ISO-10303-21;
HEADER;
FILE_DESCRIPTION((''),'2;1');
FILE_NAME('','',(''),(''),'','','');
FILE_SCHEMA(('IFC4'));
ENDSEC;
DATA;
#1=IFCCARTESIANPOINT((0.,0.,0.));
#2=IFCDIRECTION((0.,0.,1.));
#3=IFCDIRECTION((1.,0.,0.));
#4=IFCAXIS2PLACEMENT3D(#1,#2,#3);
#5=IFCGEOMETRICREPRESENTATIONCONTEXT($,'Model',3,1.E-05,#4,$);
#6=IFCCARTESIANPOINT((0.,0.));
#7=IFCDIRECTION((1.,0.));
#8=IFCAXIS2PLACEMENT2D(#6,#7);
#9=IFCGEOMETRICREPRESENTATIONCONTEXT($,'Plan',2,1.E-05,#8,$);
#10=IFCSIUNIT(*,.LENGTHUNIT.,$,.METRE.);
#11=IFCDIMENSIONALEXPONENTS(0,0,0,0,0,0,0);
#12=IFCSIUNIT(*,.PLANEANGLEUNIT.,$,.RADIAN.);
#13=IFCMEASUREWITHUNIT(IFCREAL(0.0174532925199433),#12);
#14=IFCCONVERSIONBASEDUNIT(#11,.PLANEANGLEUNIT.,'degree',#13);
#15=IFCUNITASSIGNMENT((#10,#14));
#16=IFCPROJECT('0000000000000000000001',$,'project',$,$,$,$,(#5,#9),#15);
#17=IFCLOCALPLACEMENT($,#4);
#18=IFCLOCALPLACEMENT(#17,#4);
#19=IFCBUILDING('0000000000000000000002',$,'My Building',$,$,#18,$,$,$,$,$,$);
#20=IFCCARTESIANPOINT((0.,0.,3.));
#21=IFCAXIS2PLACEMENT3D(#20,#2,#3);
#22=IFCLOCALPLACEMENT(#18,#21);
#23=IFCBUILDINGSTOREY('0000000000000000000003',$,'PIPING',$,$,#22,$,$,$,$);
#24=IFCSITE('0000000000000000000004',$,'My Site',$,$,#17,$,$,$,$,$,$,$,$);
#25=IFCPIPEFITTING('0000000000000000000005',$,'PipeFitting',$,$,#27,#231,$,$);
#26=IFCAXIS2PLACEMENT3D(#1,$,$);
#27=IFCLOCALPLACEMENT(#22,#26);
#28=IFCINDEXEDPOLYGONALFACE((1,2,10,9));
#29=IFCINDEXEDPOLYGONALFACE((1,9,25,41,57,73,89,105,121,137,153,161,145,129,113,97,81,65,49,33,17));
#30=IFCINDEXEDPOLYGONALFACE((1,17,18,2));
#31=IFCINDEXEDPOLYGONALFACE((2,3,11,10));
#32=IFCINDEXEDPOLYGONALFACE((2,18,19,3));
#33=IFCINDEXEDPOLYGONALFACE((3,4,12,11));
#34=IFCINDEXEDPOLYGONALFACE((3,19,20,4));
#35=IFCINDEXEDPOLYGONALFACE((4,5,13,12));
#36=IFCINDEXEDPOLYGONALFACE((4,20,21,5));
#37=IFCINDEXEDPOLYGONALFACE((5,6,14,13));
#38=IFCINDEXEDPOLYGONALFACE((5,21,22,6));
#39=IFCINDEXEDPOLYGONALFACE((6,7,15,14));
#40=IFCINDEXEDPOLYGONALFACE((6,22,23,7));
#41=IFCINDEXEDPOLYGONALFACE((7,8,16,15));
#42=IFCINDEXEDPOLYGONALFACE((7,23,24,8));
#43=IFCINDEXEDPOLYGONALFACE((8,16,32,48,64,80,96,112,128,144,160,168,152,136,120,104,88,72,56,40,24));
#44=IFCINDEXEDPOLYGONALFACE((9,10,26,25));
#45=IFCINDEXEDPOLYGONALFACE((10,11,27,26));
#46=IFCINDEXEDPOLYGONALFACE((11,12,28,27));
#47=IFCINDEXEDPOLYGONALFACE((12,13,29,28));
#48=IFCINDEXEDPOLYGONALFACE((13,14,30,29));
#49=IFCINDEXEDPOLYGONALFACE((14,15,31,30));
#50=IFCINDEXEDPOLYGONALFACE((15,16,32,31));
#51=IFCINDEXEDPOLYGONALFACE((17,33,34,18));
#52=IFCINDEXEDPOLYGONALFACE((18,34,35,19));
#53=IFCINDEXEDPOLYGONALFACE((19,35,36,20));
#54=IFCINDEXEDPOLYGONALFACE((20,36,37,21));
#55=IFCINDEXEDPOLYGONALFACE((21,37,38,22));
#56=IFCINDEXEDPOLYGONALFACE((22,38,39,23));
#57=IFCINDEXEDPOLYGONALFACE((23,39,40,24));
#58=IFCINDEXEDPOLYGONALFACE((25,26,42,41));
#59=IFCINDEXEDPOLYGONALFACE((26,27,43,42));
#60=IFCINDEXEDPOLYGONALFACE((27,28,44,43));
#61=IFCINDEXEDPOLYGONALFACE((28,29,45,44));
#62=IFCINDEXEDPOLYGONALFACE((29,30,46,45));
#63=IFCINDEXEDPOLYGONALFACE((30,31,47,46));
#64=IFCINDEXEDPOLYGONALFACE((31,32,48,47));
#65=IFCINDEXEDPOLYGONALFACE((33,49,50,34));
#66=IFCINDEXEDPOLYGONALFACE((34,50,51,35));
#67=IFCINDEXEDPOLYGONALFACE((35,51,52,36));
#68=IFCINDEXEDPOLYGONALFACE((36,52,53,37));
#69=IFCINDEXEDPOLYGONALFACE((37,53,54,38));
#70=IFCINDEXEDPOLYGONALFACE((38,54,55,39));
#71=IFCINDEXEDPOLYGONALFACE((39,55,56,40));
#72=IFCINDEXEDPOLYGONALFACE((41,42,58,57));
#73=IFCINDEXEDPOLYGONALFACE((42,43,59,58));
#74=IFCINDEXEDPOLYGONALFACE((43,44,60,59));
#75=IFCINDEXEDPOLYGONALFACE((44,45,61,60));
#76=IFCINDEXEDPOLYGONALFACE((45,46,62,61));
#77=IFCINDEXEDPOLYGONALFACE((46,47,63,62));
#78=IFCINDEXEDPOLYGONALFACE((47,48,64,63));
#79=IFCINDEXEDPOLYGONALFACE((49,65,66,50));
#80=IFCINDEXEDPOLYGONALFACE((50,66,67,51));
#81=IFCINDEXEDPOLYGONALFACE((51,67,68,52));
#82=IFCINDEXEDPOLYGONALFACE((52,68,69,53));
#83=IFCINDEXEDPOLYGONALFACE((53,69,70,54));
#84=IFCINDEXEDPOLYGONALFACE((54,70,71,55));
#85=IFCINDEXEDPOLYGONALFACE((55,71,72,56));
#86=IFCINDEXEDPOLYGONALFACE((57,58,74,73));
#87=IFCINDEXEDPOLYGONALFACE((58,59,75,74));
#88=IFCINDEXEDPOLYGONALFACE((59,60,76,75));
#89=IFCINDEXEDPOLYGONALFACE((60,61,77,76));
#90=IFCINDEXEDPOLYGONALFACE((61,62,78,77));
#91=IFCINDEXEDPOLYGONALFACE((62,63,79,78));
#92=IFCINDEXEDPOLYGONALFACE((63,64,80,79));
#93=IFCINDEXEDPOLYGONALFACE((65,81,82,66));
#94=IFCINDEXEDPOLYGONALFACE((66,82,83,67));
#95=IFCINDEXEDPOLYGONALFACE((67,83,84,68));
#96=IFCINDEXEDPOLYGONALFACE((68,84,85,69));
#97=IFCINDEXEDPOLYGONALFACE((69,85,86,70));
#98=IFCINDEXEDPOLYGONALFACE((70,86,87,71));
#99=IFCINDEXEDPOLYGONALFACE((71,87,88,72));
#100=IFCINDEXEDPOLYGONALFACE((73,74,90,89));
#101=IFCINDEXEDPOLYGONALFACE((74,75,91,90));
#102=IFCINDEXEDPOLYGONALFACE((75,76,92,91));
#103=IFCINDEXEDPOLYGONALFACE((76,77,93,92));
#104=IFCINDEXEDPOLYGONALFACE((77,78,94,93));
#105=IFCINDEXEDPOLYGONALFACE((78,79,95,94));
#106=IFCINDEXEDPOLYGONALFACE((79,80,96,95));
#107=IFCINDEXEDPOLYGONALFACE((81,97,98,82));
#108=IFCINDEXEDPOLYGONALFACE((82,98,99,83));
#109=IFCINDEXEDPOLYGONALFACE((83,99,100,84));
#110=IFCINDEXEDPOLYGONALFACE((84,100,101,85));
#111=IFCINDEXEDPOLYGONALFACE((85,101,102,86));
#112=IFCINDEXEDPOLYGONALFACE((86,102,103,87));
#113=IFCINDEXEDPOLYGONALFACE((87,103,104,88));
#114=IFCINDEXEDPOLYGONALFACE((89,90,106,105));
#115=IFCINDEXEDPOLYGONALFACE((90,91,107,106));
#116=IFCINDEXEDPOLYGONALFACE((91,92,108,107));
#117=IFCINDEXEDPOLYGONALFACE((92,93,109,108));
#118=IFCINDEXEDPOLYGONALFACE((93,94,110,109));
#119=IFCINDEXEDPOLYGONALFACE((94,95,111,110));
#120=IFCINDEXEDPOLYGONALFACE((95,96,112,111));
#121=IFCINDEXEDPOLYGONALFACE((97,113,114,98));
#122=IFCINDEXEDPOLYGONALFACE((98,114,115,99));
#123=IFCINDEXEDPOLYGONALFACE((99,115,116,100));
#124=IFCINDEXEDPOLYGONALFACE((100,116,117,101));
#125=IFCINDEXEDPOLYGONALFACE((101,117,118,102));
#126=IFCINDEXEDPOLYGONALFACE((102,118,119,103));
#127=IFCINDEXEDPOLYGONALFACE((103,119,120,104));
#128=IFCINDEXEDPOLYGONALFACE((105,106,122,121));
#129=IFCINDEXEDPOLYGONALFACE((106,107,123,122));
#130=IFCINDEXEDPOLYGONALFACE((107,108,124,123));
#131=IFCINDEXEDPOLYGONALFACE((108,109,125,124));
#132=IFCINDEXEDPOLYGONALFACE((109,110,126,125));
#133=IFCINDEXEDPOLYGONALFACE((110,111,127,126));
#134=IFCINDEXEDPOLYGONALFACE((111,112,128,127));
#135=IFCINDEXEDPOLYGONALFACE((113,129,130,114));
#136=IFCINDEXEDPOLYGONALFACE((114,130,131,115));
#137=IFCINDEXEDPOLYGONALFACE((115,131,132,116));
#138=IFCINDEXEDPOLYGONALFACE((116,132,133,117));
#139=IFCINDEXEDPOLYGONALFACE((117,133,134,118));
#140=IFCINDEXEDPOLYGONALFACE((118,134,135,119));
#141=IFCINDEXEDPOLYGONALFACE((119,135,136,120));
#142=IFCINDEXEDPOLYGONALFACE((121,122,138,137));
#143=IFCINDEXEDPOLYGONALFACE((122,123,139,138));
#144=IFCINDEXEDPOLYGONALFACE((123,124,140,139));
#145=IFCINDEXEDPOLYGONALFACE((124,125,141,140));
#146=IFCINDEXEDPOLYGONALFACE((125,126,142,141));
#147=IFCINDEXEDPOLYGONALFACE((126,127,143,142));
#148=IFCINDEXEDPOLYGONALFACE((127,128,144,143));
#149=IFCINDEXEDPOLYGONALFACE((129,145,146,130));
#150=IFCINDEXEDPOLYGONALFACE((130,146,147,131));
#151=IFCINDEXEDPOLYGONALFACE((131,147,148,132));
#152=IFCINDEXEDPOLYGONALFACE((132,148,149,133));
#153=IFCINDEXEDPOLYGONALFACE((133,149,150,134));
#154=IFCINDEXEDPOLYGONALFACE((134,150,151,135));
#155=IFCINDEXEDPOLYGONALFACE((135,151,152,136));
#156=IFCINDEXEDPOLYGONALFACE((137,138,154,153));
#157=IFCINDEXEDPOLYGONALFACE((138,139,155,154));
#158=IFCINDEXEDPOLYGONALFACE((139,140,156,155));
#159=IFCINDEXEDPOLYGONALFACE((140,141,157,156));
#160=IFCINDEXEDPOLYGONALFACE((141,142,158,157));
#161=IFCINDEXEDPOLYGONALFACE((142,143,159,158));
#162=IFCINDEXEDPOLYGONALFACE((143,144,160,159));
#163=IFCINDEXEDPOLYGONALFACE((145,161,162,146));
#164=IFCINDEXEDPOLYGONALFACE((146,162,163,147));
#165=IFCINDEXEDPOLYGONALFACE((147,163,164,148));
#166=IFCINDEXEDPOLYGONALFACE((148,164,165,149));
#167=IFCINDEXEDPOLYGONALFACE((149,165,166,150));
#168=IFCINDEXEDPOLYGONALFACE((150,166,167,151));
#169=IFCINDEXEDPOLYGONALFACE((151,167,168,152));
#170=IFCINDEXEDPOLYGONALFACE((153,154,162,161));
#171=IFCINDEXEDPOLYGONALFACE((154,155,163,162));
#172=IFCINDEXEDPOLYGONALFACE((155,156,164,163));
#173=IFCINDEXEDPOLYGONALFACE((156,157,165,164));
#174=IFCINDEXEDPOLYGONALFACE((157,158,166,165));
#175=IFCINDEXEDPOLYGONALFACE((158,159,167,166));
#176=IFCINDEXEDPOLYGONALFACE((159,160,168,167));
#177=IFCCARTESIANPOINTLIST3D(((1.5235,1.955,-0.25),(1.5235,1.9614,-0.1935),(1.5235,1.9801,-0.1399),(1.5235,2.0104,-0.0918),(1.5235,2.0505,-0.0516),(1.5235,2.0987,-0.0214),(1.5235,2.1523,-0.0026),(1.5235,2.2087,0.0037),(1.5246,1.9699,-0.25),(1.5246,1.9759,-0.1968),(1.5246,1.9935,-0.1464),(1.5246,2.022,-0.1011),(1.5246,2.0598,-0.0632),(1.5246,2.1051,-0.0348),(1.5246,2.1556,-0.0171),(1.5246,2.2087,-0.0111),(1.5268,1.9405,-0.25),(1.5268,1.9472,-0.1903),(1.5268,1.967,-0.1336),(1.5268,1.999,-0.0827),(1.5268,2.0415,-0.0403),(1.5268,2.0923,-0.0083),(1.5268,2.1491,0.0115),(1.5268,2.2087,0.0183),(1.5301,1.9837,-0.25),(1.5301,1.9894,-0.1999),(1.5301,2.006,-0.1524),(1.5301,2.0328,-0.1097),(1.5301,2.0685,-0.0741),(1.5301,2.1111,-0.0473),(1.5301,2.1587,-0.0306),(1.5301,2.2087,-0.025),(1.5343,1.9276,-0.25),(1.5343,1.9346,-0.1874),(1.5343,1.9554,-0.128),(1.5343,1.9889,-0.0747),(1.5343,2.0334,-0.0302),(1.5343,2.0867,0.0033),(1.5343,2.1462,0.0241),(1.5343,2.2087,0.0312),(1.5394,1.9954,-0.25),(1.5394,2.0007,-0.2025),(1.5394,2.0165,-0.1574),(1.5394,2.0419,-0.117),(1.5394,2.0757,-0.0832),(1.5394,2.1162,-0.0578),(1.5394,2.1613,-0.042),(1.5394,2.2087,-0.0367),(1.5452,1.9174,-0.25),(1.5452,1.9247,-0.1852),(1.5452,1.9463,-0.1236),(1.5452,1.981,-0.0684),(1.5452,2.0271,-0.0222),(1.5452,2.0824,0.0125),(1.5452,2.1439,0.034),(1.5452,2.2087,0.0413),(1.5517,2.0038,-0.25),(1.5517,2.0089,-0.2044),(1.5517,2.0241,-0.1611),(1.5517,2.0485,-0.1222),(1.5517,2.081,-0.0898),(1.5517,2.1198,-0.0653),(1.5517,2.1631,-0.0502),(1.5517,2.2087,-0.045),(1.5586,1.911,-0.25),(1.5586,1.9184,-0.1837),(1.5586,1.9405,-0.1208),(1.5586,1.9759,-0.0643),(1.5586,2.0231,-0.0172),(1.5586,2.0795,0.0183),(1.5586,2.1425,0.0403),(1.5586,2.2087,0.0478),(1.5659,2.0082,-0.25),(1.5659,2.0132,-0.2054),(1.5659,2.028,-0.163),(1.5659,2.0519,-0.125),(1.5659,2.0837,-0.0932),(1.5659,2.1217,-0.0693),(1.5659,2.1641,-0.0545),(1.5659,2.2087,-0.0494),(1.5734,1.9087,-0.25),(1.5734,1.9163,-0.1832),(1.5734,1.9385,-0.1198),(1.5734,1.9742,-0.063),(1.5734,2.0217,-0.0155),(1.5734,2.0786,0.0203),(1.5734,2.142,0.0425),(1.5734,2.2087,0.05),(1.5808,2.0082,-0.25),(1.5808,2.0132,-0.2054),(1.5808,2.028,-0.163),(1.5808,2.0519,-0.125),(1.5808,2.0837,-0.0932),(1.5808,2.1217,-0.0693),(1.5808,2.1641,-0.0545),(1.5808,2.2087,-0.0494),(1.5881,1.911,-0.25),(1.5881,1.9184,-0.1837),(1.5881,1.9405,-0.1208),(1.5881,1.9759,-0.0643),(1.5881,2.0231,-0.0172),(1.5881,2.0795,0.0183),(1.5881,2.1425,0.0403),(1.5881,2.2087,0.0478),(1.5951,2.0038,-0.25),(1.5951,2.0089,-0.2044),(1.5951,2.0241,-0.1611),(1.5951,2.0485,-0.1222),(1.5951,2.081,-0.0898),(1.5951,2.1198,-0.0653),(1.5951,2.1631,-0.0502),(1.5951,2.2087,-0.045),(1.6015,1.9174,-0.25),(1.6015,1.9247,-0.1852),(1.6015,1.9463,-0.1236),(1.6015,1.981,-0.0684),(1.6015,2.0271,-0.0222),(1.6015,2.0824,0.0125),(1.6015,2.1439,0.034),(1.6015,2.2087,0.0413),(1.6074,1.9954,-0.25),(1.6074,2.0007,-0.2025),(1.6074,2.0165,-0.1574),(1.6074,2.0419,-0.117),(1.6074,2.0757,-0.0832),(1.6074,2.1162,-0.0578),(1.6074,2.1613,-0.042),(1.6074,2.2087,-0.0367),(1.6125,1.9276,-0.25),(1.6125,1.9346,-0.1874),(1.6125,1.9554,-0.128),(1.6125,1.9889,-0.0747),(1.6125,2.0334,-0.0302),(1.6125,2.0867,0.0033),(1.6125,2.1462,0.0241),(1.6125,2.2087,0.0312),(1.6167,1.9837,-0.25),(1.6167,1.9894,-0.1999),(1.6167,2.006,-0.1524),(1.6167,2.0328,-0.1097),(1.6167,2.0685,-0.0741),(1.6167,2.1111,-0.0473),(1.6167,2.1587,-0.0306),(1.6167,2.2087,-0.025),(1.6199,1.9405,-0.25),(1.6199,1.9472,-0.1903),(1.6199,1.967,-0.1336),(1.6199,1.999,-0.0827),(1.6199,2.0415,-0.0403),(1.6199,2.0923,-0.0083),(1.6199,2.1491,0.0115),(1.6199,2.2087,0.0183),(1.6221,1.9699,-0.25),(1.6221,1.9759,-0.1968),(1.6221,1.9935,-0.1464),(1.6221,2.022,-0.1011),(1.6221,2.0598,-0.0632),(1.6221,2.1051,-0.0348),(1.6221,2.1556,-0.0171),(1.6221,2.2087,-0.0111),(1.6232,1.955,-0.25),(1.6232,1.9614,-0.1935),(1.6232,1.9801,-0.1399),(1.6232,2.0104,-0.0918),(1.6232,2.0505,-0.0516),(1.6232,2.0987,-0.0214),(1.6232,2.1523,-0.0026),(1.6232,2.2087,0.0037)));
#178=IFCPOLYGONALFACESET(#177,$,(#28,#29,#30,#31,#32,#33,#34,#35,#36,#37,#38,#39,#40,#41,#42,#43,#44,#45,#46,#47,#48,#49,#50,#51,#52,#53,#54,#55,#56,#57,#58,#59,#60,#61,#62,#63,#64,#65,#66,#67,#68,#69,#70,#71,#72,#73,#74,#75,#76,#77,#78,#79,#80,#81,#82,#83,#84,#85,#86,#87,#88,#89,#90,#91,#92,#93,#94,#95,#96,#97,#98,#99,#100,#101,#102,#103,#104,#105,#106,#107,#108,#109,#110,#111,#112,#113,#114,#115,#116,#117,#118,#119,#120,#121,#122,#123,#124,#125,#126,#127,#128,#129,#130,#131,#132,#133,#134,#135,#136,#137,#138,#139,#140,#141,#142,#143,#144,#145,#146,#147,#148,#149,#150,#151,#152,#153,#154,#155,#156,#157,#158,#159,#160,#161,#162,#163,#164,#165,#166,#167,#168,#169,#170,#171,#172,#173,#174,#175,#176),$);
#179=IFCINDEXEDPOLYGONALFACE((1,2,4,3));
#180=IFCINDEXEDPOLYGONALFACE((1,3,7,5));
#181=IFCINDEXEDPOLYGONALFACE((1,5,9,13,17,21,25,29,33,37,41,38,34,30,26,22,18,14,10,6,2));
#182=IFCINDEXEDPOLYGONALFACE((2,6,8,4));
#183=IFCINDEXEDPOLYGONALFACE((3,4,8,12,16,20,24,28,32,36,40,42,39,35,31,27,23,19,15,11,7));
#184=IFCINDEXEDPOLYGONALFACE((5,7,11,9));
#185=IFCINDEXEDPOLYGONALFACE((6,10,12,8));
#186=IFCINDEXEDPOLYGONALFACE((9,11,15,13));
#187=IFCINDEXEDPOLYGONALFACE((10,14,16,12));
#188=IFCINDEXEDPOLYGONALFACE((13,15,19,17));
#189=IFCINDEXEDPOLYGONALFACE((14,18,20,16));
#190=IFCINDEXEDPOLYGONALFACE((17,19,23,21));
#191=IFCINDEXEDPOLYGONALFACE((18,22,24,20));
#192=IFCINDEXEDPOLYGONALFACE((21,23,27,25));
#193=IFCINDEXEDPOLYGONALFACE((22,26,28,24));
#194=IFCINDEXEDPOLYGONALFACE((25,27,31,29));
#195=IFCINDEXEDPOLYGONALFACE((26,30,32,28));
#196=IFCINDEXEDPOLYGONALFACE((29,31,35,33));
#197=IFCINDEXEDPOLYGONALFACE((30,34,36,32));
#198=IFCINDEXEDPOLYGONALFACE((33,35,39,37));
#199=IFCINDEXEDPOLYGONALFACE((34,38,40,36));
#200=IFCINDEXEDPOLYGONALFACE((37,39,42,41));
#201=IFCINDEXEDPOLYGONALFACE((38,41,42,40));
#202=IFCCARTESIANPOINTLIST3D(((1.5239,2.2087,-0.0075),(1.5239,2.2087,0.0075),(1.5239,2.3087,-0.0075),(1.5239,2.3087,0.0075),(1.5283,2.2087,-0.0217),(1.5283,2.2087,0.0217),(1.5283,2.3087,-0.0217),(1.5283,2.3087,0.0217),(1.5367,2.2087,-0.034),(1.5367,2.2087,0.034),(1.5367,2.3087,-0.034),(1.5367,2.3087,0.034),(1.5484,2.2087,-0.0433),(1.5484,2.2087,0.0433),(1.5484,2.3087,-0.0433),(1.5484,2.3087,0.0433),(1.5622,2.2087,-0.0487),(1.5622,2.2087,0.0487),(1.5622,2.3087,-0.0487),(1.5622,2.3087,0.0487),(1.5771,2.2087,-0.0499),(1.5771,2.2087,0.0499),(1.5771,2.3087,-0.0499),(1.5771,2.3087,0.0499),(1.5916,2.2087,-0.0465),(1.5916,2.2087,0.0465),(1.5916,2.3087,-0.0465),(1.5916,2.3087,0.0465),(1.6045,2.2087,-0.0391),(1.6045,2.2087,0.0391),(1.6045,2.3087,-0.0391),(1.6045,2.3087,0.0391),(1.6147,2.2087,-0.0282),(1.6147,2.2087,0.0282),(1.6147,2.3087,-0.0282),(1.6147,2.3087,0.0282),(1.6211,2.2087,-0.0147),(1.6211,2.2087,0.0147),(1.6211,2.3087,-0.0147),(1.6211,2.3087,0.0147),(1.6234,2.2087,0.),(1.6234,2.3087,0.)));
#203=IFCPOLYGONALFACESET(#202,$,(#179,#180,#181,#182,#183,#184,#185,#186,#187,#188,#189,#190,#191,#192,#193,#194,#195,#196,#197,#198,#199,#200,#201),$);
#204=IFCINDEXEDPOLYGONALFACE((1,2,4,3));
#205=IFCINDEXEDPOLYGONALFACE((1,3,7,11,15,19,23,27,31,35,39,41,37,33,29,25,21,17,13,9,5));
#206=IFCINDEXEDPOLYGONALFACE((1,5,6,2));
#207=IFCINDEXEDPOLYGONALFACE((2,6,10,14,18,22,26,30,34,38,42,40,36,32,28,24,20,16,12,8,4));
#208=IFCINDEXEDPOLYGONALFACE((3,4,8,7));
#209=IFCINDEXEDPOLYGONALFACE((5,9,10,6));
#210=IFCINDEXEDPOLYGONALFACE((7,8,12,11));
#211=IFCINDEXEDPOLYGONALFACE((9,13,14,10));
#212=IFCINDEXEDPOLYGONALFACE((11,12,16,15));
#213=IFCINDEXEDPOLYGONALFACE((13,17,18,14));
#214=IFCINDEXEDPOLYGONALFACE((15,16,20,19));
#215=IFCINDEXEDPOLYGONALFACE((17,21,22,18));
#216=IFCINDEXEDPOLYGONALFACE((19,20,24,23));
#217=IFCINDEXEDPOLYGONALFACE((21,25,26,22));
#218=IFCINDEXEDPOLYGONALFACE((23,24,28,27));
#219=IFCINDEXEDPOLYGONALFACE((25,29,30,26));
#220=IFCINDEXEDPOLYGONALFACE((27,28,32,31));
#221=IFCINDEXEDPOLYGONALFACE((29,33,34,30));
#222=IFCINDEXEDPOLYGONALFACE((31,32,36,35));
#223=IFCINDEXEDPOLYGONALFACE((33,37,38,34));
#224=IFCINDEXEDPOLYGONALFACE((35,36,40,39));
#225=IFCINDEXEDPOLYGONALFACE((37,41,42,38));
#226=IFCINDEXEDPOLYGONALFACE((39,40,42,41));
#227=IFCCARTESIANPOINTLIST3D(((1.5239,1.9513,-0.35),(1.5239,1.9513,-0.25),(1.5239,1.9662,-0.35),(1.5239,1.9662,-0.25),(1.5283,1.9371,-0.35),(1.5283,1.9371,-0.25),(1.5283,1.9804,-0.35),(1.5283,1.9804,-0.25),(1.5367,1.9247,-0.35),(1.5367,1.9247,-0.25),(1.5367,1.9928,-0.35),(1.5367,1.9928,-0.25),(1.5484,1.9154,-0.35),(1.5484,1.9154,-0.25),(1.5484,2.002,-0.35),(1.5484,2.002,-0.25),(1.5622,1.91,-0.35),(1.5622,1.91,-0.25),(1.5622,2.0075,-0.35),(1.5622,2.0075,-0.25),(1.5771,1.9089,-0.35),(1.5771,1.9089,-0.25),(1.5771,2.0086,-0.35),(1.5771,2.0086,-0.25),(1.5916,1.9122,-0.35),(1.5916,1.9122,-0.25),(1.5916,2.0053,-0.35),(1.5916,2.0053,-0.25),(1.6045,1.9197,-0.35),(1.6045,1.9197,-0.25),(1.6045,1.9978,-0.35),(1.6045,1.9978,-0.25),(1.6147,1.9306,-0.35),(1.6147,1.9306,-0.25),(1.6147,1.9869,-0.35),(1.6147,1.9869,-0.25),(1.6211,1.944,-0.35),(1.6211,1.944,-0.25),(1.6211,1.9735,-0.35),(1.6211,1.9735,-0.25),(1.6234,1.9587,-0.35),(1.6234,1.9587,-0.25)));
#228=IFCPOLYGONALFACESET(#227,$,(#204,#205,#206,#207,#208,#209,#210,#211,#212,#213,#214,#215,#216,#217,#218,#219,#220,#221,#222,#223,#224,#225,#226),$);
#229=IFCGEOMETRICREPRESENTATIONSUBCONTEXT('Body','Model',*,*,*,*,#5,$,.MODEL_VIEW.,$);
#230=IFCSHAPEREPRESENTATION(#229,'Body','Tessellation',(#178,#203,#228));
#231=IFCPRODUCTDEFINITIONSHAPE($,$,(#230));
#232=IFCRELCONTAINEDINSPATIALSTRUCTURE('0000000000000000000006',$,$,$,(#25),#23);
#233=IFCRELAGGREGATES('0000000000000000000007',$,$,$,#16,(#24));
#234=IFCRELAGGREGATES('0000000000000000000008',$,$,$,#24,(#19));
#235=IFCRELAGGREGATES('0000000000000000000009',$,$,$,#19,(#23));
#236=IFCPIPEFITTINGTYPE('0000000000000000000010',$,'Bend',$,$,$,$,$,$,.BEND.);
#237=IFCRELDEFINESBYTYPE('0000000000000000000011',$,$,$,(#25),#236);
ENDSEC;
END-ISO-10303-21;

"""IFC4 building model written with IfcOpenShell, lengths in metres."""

from ifc_helpers import new_model, entity, si_unit, converted_unit, frame, origin_with_axes, origin_2d_with_axis, place, context, subcontext, project, spatial, line, indexed_curve, circle, outline, extrude, source, transform, mapped, type_object, type_shapes, element, save


model = new_model("IFC4")

# Units and contexts
model_context = context("Model", 3, precision=1e-05, world=origin_with_axes())
plan_context = context("Plan", 2, precision=1e-05, world=origin_2d_with_axis())
body_context = subcontext(model_context, "Body", "Model", "MODEL_VIEW")
ifc_project = project(units=[si_unit("LENGTHUNIT", "METRE"), converted_unit("PLANEANGLEUNIT", "degree", entity("IfcReal", 0.0174532925199433), si_unit("PLANEANGLEUNIT", "RADIAN"), dimensions=[0, 0, 0, 0, 0, 0, 0])], contexts=[model_context, plan_context])

# Site, building, storey
site_placement = place(None, origin_with_axes())
site = spatial("IfcSite", under=ifc_project, at=site_placement, Name="My Site")
building_placement = place(site_placement, origin_with_axes())
building = spatial("IfcBuilding", under=site, at=building_placement, Name="My Building")
storey_placement = place(building_placement, frame((0.0, 0.0, 3.0), z_axis=(0.0, 0.0, 1.0), x_axis=(1.0, 0.0, 0.0)))
storey = spatial("IfcBuildingStorey", under=building, at=storey_placement, Name="PIPING")

# Pipe fitting, opening
pipe_fitting_type = type_object("IfcPipeFittingType", Name="Bend", PredefinedType="BEND")
shared_shape = source(origin_with_axes(), body_context, "Body", "SolidModel", [
    entity("IfcSweptDiskSolid", entity("IfcIndexedPolyCurve", entity("IfcCartesianPointList3D", [[0.0, 0.0, 0.1], [0.0, -0.0732, 0.2768], [0.0, -0.25, 0.35]]), [entity("IfcArcIndex", [1, 2, 3])]), 0.05),
    extrude(circle(Radius=0.05), origin_with_axes(), (0.0, 0.0, 1.0), 0.1),
    extrude(circle(Radius=0.05), frame((0.0, -0.25, 0.35), z_axis=(0.0, -1.0, 0.0), x_axis=(1.0, 0.0, 0.0)), (0.0, 0.0, 1.0), 0.1),
])
type_shapes(pipe_fitting_type, [shared_shape])
pipe_fitting_1_placement = place(storey_placement, frame((1.5734, 2.3087, 0.0), z_axis=(0.0, -1.0, 0.0), x_axis=(1.0, 0.0, 0.0)))
pipe_fitting_1 = element("IfcPipeFitting", 1, at=pipe_fitting_1_placement, inside=storey, type_object=pipe_fitting_type, Name="PipeFitting", context=body_context, shape_type="MappedRepresentation", body=[
    mapped(shared_shape, transform((0.0, 0.0, 0.0), x_axis=(1.0, 0.0, 0.0), y_axis=(0.0, 1.0, 0.0), z_axis=(0.0, 0.0, 1.0), scale=1.0)),
])
opening_1_placement = place(pipe_fitting_1_placement, frame((-1.5734, -3.0, 2.3087), z_axis=(0.0, 1.0, 0.0), x_axis=(1.0, 0.0, 0.0)))
element("IfcOpeningElement", 2, at=opening_1_placement, cuts=pipe_fitting_1, PredefinedType="OPENING", context=body_context, shape_type="SweptSolid", body=[
    extrude(outline(indexed_curve([(0.0, 0.0), (0.5, 0.0), (0.5, 0.5), (0.0, 0.5)], segments=[line(1, 2, 3, 4, 1)])), origin_with_axes(), (0.0, 0.0, 1.0), 0.5),
])

save(model, "model.ifc")
